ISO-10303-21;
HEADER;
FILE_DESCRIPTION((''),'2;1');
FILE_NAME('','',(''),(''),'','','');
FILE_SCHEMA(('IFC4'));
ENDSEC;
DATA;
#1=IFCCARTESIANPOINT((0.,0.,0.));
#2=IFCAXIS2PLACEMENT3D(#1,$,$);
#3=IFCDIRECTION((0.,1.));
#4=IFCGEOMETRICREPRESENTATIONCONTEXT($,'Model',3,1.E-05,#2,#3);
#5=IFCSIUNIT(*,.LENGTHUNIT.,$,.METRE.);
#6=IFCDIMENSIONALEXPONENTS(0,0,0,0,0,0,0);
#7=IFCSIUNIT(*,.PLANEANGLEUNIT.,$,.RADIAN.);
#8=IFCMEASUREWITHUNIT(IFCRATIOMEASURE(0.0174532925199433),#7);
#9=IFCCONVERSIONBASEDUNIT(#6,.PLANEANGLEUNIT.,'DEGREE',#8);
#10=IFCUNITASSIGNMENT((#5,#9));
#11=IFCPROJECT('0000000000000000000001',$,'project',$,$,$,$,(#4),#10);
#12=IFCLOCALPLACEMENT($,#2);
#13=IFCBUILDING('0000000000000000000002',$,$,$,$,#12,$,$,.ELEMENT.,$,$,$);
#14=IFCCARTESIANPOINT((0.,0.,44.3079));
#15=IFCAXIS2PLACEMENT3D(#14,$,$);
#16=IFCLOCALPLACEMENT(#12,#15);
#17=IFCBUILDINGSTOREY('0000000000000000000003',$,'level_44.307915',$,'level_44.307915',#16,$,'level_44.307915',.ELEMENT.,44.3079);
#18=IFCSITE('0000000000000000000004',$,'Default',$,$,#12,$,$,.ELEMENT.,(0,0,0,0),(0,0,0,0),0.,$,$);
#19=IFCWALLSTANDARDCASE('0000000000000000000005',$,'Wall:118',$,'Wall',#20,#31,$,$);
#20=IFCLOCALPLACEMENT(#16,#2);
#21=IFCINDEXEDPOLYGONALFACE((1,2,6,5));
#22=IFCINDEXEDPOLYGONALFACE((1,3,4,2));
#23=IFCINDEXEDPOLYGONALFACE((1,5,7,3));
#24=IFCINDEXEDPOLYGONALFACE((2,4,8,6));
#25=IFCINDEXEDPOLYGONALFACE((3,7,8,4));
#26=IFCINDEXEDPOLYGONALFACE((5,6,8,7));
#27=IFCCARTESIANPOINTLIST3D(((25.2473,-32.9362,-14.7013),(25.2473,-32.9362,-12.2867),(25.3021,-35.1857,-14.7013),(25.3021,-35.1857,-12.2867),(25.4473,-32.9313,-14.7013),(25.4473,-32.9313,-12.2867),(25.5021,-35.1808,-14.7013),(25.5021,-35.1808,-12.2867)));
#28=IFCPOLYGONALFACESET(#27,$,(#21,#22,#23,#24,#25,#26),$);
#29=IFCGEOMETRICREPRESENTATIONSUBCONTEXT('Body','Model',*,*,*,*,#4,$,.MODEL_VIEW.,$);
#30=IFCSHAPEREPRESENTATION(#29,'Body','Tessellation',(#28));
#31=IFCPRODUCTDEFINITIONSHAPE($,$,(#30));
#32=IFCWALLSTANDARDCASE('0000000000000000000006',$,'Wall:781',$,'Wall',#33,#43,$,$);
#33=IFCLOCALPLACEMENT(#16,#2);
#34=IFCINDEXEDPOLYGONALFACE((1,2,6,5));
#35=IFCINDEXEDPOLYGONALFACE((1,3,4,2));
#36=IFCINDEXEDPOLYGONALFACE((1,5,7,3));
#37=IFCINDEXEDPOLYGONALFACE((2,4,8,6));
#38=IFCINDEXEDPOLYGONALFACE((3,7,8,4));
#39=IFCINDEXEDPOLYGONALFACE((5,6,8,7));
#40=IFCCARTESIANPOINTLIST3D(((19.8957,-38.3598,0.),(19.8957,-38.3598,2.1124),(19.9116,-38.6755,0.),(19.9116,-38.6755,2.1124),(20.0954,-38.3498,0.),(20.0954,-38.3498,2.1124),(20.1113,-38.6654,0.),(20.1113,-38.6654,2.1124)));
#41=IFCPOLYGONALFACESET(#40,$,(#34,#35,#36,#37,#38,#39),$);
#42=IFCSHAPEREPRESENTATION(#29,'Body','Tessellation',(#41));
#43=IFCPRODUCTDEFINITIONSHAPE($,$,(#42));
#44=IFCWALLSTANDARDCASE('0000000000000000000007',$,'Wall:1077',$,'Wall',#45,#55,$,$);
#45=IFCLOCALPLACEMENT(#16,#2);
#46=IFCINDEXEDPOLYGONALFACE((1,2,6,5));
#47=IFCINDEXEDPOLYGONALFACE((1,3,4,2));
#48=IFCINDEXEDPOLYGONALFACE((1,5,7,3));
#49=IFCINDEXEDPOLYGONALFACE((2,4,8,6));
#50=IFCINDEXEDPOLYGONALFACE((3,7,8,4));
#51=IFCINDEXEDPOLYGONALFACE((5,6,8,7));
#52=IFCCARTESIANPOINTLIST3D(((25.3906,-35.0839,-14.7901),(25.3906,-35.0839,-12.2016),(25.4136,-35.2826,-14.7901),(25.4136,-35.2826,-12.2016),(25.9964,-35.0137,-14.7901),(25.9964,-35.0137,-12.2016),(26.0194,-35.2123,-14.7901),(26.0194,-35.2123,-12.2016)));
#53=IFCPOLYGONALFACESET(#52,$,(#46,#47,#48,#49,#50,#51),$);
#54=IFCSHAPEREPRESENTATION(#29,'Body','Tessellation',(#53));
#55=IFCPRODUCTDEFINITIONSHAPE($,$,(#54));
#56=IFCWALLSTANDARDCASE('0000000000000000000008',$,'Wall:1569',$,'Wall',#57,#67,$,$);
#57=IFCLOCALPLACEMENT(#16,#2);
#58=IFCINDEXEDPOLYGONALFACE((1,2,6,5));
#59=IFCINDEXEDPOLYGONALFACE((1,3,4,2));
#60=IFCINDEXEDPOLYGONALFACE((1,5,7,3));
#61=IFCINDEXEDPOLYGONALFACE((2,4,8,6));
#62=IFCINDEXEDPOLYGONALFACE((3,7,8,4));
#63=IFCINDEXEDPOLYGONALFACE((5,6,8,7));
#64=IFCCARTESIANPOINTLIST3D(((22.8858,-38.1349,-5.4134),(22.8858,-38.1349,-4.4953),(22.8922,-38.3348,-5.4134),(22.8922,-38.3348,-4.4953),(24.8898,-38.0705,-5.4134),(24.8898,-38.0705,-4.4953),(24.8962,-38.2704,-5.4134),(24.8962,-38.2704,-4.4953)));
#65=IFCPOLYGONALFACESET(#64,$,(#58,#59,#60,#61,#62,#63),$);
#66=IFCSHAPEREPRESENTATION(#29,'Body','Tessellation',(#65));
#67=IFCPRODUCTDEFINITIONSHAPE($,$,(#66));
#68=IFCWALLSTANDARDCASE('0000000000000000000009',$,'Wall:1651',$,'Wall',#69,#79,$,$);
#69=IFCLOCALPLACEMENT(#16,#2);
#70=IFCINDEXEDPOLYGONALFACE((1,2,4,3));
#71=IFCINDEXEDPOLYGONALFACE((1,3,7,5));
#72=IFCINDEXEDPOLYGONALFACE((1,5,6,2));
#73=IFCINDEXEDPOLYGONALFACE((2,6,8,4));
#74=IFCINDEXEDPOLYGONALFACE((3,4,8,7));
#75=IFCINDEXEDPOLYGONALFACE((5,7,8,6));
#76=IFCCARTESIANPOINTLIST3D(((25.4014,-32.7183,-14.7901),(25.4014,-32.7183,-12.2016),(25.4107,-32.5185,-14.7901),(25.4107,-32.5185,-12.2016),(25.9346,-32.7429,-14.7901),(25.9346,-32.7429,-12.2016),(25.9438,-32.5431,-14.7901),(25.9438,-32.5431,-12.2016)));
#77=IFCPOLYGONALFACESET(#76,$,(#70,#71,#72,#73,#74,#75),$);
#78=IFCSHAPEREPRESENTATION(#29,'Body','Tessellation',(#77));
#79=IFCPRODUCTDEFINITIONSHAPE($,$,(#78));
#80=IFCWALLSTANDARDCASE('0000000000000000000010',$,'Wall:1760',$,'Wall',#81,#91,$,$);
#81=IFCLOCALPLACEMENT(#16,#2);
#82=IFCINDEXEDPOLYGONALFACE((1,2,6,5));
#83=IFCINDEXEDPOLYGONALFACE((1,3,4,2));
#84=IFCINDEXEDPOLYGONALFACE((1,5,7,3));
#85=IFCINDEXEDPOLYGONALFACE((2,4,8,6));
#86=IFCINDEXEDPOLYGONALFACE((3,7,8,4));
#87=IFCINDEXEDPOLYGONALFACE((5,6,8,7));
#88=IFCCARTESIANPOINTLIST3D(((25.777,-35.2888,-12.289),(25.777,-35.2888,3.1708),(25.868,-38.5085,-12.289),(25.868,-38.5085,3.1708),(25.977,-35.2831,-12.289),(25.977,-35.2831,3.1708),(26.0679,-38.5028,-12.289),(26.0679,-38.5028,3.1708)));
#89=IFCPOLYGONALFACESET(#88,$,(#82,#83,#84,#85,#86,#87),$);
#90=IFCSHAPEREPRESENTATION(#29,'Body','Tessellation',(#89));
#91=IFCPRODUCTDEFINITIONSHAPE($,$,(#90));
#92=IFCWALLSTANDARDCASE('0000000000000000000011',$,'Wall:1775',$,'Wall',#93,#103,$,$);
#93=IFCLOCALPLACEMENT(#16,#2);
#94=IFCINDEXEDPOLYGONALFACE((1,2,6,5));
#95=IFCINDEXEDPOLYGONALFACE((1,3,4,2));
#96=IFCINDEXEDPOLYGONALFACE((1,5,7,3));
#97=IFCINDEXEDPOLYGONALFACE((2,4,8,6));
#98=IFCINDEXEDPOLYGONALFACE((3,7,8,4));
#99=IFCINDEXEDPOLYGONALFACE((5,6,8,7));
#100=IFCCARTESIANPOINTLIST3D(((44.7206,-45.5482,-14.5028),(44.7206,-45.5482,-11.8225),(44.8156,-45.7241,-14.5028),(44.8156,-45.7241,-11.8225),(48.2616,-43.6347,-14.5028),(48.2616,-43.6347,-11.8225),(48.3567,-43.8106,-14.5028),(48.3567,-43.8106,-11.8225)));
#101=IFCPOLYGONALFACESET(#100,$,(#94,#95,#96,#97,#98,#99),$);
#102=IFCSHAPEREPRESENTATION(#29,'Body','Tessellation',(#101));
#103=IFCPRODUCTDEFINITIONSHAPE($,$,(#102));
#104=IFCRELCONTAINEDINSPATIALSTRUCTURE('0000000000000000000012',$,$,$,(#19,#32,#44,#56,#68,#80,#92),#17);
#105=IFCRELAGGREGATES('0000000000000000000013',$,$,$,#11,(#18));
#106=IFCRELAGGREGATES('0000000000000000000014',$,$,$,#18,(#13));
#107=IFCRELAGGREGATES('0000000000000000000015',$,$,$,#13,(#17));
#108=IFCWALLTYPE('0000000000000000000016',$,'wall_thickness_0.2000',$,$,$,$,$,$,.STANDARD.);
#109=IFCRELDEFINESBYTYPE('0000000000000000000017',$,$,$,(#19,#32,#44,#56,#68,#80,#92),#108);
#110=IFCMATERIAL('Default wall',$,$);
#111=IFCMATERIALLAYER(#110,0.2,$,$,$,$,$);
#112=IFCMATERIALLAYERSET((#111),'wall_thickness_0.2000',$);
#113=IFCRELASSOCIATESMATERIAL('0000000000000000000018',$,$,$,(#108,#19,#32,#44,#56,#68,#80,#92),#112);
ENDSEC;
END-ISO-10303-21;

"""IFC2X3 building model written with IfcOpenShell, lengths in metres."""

from ifc_helpers import new_model, entity, si_unit, converted_unit, direction, frame, origin, place, context, subcontext, project, spatial, polyline, outline, extrude, material, layer, layer_set, layer_usage, type_object, element, save


model = new_model("IFC2X3")

# Units and contexts
model_context = context("Model", 3, precision=1e-05, world=origin(), true_north=direction((0.0, 1.0)))
body_context = subcontext(model_context, "Body", "Model", "MODEL_VIEW")
ifc_project = project(units=[si_unit("LENGTHUNIT", "METRE"), converted_unit("PLANEANGLEUNIT", "DEGREE", entity("IfcRatioMeasure", 0.0174532925199433), si_unit("PLANEANGLEUNIT", "RADIAN"), dimensions=[0, 0, 0, 0, 0, 0, 0])], contexts=[model_context])

# Site, building, storey
placement_1 = place(None, origin())
site = spatial("IfcSite", under=ifc_project, at=placement_1, Name="Default", CompositionType="ELEMENT", RefLatitude=(0, 0, 0, 0), RefLongitude=(0, 0, 0, 0), RefElevation=0.0)
building = spatial("IfcBuilding", under=site, at=placement_1, CompositionType="ELEMENT")
storey_placement = place(placement_1, frame((0.0, 0.0, 44.3079)))
storey = spatial("IfcBuildingStorey", under=building, at=storey_placement, Name="level_44.307915", ObjectType="level_44.307915", LongName="level_44.307915", CompositionType="ELEMENT", Elevation=44.3079)

# Walls
ifc_material_1 = material(Name="Default wall")
ifc_layer = layer(ifc_material_1, 0.2)
ifc_layer_set = layer_set([ifc_layer], Name="wall_thickness_0.2000")
ifc_layer_usage = layer_usage(ifc_layer_set, "AXIS2", "POSITIVE", -0.1)
wall_type = type_object("IfcWallType", Name="wall_thickness_0.2000", PredefinedType="STANDARD", material=ifc_layer_set)
placement_2 = place(placement_1, frame((0.0, 0.0, 29.6066)))
wall_1_placement = place(placement_2, frame((25.3473, -32.9337, 0.0), z_axis=(0.0, 0.0, 1.0), x_axis=(0.024361, -0.999703, 0.0)))
element("IfcWallStandardCase", 1, at=wall_1_placement, inside=storey, type_object=wall_type, material=ifc_layer_usage, Name="Wall:118", ObjectType="Wall", context=body_context, shape_type="SweptSolid", body=[
    extrude(outline(polyline([(2.2502, -0.1), (2.2502, 0.1), (0.0, 0.1), (0.0, -0.1), (2.2502, -0.1)])), origin(), (0.0, 0.0, 1.0), 2.4146),
])
wall_2_placement = place(storey_placement, frame((20.0115, -38.6704, 0.0), z_axis=(0.0, 0.0, 1.0), x_axis=(-0.050261, 0.998736, 0.0)))
element("IfcWallStandardCase", 2, at=wall_2_placement, inside=storey, type_object=wall_type, material=ifc_layer_usage, Name="Wall:781", ObjectType="Wall", context=body_context, shape_type="SweptSolid", body=[
    extrude(outline(polyline([(0.316, -0.1), (0.316, 0.1), (0.0, 0.1), (0.0, -0.1), (0.316, -0.1)])), origin(), (0.0, 0.0, 1.0), 2.1124),
])
placement_3 = place(placement_1, frame((0.0, 0.0, 29.5178)))
wall_3_placement = place(placement_3, frame((26.0079, -35.113, 0.0), z_axis=(0.0, 0.0, 1.0), x_axis=(-0.993348, -0.115153, 0.0)))
element("IfcWallStandardCase", 3, at=wall_3_placement, inside=storey, type_object=wall_type, material=ifc_layer_usage, Name="Wall:1077", ObjectType="Wall", context=body_context, shape_type="SweptSolid", body=[
    extrude(outline(polyline([(0.6099, -0.1), (0.6099, 0.1), (0.0, 0.1), (0.0, -0.1), (0.6099, -0.1)])), origin(), (0.0, 0.0, 1.0), 2.5885),
])

# Walls
placement_4 = place(placement_1, frame((0.0, 0.0, 38.8945)))
wall_4_placement = place(placement_4, frame((22.889, -38.2349, 0.0), z_axis=(0.0, 0.0, 1.0), x_axis=(0.999485, 0.032099, 0.0)))
element("IfcWallStandardCase", 4, at=wall_4_placement, inside=storey, type_object=wall_type, material=ifc_layer_usage, Name="Wall:1569", ObjectType="Wall", context=body_context, shape_type="SweptSolid", body=[
    extrude(outline(polyline([(2.005, -0.1), (2.005, 0.1), (0.0, 0.1), (0.0, -0.1), (2.005, -0.1)])), origin(), (0.0, 0.0, 1.0), 0.9181),
])
placement_5 = place(placement_1, frame((0.0, 0.0, 29.5178)))
wall_5_placement = place(placement_5, frame((25.9392, -32.643, 0.0), z_axis=(0.0, 0.0, 1.0), x_axis=(-0.998936, 0.046121, 0.0)))
element("IfcWallStandardCase", 5, at=wall_5_placement, inside=storey, type_object=wall_type, material=ifc_layer_usage, Name="Wall:1651", ObjectType="Wall", context=body_context, shape_type="SweptSolid", body=[
    extrude(outline(polyline([(0.5337, -0.1), (0.5337, 0.1), (0.0, 0.1), (0.0, -0.1), (0.5337, -0.1)])), origin(), (0.0, 0.0, 1.0), 2.5885),
])
placement_6 = place(placement_1, frame((0.0, 0.0, 32.0189)))
wall_6_placement = place(placement_6, frame((25.877, -35.2859, 0.0), z_axis=(0.0, 0.0, 1.0), x_axis=(0.028231, -0.999601, 0.0)))
element("IfcWallStandardCase", 6, at=wall_6_placement, inside=storey, type_object=wall_type, material=ifc_layer_usage, Name="Wall:1760", ObjectType="Wall", context=body_context, shape_type="SweptSolid", body=[
    extrude(outline(polyline([(3.221, -0.1), (3.221, 0.1), (0.0, 0.1), (0.0, -0.1), (3.221, -0.1)])), origin(), (0.0, 0.0, 1.0), 15.4598),
])
placement_7 = place(placement_1, frame((0.0, 0.0, 29.8051)))
wall_7_placement = place(placement_7, frame((44.7681, -45.6362, 0.0), z_axis=(0.0, 0.0, 1.0), x_axis=(0.879769, 0.475401, 0.0)))
element("IfcWallStandardCase", 7, at=wall_7_placement, inside=storey, type_object=wall_type, material=ifc_layer_usage, Name="Wall:1775", ObjectType="Wall", context=body_context, shape_type="SweptSolid", body=[
    extrude(outline(polyline([(4.025, -0.1), (4.025, 0.1), (0.0, 0.1), (0.0, -0.1), (4.025, -0.1)])), origin(), (0.0, 0.0, 1.0), 2.6804),
])

save(model, "model.ifc")
